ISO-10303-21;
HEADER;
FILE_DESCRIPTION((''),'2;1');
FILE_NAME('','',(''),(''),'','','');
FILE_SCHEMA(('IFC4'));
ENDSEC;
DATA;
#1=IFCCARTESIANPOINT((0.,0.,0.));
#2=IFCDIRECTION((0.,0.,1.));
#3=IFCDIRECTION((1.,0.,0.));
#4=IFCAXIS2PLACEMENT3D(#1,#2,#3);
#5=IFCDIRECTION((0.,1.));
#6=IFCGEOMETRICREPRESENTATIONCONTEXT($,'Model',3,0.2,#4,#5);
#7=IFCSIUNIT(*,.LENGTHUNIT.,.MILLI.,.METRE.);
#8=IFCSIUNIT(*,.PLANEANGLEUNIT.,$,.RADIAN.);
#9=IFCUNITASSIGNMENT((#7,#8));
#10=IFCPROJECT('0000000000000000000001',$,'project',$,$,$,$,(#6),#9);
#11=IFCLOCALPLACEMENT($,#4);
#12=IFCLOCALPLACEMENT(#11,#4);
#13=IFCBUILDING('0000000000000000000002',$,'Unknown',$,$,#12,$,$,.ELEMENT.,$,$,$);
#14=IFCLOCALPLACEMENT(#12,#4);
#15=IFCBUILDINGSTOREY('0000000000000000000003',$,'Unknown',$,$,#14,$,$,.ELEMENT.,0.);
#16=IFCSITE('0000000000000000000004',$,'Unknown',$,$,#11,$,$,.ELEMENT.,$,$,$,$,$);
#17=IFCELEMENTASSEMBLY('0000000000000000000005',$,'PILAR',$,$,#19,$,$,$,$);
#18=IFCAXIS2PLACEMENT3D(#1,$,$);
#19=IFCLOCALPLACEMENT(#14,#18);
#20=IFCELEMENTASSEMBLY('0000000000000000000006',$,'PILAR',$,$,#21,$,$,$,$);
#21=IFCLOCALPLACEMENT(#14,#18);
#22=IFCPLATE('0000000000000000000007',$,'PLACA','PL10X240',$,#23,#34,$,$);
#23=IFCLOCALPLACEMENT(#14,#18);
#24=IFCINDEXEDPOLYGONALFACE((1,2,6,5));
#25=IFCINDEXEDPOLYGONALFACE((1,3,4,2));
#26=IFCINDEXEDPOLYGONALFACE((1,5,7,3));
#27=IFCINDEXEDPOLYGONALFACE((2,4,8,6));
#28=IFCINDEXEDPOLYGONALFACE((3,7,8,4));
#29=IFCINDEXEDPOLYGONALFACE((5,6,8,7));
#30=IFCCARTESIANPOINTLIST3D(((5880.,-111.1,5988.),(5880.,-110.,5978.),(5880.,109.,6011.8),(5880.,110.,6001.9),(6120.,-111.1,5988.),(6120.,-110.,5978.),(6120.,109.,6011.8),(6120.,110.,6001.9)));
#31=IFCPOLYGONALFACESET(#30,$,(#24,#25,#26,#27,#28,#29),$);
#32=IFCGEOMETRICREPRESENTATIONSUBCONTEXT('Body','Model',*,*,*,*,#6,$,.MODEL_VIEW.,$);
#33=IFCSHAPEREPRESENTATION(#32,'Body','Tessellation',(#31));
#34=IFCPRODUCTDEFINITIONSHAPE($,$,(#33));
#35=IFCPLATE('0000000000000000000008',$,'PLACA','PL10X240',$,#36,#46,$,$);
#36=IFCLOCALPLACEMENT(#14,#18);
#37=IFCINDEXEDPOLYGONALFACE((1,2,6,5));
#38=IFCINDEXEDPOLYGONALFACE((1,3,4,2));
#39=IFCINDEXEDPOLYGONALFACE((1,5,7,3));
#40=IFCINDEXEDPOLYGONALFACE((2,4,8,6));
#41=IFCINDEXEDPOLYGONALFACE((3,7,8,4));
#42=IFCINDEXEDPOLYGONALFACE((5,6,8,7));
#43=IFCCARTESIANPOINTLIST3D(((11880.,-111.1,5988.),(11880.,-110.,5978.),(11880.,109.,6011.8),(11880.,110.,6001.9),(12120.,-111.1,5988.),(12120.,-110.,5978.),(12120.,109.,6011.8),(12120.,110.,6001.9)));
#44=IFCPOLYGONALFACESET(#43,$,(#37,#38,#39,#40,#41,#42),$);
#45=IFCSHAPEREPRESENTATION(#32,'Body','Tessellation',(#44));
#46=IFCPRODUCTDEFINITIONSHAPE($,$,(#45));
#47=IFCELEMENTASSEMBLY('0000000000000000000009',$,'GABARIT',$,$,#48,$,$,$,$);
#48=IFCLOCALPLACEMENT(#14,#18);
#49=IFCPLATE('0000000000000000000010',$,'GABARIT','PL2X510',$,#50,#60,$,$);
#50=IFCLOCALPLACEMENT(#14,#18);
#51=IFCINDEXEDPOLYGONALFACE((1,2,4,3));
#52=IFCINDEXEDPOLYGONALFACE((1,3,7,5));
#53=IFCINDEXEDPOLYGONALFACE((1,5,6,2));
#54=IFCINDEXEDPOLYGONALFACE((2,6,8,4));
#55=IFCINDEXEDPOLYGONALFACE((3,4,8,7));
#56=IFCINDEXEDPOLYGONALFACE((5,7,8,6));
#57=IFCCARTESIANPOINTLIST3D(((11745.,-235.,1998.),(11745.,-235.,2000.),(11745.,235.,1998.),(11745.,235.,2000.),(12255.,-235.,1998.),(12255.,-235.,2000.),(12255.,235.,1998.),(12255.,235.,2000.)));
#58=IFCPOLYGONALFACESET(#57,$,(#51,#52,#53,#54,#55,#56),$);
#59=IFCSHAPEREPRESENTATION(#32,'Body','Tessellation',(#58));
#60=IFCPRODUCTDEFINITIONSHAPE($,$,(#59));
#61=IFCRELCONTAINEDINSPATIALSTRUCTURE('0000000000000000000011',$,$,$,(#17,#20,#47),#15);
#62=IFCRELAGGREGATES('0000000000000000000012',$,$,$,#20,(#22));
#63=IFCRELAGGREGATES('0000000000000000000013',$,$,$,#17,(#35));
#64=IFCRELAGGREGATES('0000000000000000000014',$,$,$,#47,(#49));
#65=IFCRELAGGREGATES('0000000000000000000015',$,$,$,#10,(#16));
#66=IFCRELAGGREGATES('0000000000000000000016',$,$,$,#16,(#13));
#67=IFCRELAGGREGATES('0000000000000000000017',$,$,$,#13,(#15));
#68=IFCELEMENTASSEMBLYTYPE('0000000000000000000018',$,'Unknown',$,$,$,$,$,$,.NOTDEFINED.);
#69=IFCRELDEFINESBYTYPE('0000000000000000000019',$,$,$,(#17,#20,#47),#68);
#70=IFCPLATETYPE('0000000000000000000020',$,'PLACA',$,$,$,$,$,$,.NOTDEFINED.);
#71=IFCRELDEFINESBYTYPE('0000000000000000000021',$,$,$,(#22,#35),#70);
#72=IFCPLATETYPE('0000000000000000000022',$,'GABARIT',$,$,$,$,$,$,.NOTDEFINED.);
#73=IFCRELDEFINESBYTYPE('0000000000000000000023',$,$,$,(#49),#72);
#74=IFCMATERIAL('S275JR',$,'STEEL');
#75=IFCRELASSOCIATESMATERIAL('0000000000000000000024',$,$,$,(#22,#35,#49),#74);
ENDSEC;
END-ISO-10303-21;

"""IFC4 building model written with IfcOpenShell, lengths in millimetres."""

from ifc_helpers import new_model, si_unit, direction, frame, origin_with_axes, origin_2d_with_axis, place, context, subcontext, project, spatial, rectangle, extrude, material, material_profile, profile_set, profile_usage, type_object, element, aggregate, save


model = new_model("IFC4")

# Units and contexts
model_context = context("Model", 3, precision=0.2, world=origin_with_axes(), true_north=direction((0.0, 1.0)))
body_context = subcontext(model_context, "Body", "Model", "MODEL_VIEW")
ifc_project = project(units=[si_unit("LENGTHUNIT", "METRE", prefix="MILLI"), si_unit("PLANEANGLEUNIT", "RADIAN")], contexts=[model_context])

# Site, building, storey
site_placement = place(None, origin_with_axes())
site = spatial("IfcSite", under=ifc_project, at=site_placement, Name="Unknown", CompositionType="ELEMENT")
building_placement = place(site_placement, origin_with_axes())
building = spatial("IfcBuilding", under=site, at=building_placement, Name="Unknown", CompositionType="ELEMENT")
storey_placement = place(building_placement, origin_with_axes())
storey = spatial("IfcBuildingStorey", under=building, at=storey_placement, Name="Unknown", CompositionType="ELEMENT", Elevation=0.0)

# Element assembly
element_assembly_type = type_object("IfcElementAssemblyType", Name="Unknown", PredefinedType="NOTDEFINED")
assembly_1_placement = place(storey_placement, frame((12000.0, 0.0, 2000.0), z_axis=(1.0, 0.0, 0.0), x_axis=(0.0, 0.0, 1.0)))
assembly_1 = element("IfcElementAssembly", 1, at=assembly_1_placement, inside=storey, type_object=element_assembly_type, Name="PILAR")

# Shared definitions
ifc_material_1 = material(Name="S275JR", Category="STEEL")

# Element assembly, plate
assembly_2_placement = place(storey_placement, frame((6000.0, 0.0, 2000.0), z_axis=(1.0, 0.0, 0.0), x_axis=(0.0, 0.0, 1.0)))
assembly_2 = element("IfcElementAssembly", 2, at=assembly_2_placement, inside=storey, type_object=element_assembly_type, Name="PILAR")
ifc_material_profile_1 = material_profile(ifc_material_1, rectangle(XDim=221.3, YDim=240.0, at=origin_2d_with_axis()), Name="PL10X240")
ifc_profile_set_1 = profile_set([ifc_material_profile_1])
ifc_profile_usage_1 = profile_usage(ifc_profile_set_1, cardinal=2)
plate_type_1 = type_object("IfcPlateType", Name="PLACA", PredefinedType="NOTDEFINED")
plate_1_placement = place(assembly_2_placement, frame((4006.8, -109.5, 0.0), z_axis=(-0.107703, 0.994183, 0.0), x_axis=(-0.994183, -0.107703, 0.0)))
plate_1 = element("IfcPlate", 3, at=plate_1_placement, type_object=plate_type_1, material=ifc_profile_usage_1, Name="PLACA", Description="PL10X240", context=body_context, shape_type="SolidModel", body=[
    extrude(rectangle(XDim=221.3, YDim=240.0, at=origin_2d_with_axis()), frame((-5.0, 0.0, 110.7), z_axis=(-1.0, 0.0, 0.0), x_axis=(0.0, 0.0, 1.0)), (0.0, 0.0, -1.0), 10.0),
])
aggregate(assembly_2, [plate_1])

# Plate
plate_2_placement = place(assembly_1_placement, frame((4006.8, -109.5, 0.0), z_axis=(-0.107703, 0.994183, 0.0), x_axis=(-0.994183, -0.107703, 0.0)))
plate_2 = element("IfcPlate", 4, at=plate_2_placement, type_object=plate_type_1, material=ifc_profile_usage_1, Name="PLACA", Description="PL10X240", context=body_context, shape_type="SolidModel", body=[
    extrude(rectangle(XDim=221.3, YDim=240.0, at=origin_2d_with_axis()), frame((-5.0, 0.0, 110.7), z_axis=(-1.0, 0.0, 0.0), x_axis=(0.0, 0.0, 1.0)), (0.0, 0.0, -1.0), 10.0),
])
aggregate(assembly_1, [plate_2])

# Element assembly, plate
assembly_3_placement = place(storey_placement, frame((12000.0, 235.0, 1999.0), z_axis=(0.0, 0.0, 1.0), x_axis=(0.0, -1.0, 0.0)))
assembly_3 = element("IfcElementAssembly", 5, at=assembly_3_placement, inside=storey, type_object=element_assembly_type, Name="GABARIT")
ifc_material_profile_2 = material_profile(ifc_material_1, rectangle(XDim=470.0, YDim=510.0, at=origin_2d_with_axis()), Name="PL2X510")
ifc_profile_set_2 = profile_set([ifc_material_profile_2])
ifc_profile_usage_2 = profile_usage(ifc_profile_set_2, cardinal=2)
plate_type_2 = type_object("IfcPlateType", Name="GABARIT", PredefinedType="NOTDEFINED")
plate_3_placement = place(assembly_3_placement, frame((470.0, 0.0, 0.0), z_axis=(-1.0, 0.0, 0.0), x_axis=(0.0, 0.0, 1.0)))
plate_3 = element("IfcPlate", 6, at=plate_3_placement, type_object=plate_type_2, material=ifc_profile_usage_2, Name="GABARIT", Description="PL2X510", context=body_context, shape_type="SolidModel", body=[
    extrude(rectangle(XDim=470.0, YDim=510.0, at=origin_2d_with_axis()), frame((-1.0, 0.0, 235.0), z_axis=(-1.0, 0.0, 0.0), x_axis=(0.0, 0.0, 1.0)), (0.0, 0.0, -1.0), 2.0),
])
aggregate(assembly_3, [plate_3])

save(model, "model.ifc")
